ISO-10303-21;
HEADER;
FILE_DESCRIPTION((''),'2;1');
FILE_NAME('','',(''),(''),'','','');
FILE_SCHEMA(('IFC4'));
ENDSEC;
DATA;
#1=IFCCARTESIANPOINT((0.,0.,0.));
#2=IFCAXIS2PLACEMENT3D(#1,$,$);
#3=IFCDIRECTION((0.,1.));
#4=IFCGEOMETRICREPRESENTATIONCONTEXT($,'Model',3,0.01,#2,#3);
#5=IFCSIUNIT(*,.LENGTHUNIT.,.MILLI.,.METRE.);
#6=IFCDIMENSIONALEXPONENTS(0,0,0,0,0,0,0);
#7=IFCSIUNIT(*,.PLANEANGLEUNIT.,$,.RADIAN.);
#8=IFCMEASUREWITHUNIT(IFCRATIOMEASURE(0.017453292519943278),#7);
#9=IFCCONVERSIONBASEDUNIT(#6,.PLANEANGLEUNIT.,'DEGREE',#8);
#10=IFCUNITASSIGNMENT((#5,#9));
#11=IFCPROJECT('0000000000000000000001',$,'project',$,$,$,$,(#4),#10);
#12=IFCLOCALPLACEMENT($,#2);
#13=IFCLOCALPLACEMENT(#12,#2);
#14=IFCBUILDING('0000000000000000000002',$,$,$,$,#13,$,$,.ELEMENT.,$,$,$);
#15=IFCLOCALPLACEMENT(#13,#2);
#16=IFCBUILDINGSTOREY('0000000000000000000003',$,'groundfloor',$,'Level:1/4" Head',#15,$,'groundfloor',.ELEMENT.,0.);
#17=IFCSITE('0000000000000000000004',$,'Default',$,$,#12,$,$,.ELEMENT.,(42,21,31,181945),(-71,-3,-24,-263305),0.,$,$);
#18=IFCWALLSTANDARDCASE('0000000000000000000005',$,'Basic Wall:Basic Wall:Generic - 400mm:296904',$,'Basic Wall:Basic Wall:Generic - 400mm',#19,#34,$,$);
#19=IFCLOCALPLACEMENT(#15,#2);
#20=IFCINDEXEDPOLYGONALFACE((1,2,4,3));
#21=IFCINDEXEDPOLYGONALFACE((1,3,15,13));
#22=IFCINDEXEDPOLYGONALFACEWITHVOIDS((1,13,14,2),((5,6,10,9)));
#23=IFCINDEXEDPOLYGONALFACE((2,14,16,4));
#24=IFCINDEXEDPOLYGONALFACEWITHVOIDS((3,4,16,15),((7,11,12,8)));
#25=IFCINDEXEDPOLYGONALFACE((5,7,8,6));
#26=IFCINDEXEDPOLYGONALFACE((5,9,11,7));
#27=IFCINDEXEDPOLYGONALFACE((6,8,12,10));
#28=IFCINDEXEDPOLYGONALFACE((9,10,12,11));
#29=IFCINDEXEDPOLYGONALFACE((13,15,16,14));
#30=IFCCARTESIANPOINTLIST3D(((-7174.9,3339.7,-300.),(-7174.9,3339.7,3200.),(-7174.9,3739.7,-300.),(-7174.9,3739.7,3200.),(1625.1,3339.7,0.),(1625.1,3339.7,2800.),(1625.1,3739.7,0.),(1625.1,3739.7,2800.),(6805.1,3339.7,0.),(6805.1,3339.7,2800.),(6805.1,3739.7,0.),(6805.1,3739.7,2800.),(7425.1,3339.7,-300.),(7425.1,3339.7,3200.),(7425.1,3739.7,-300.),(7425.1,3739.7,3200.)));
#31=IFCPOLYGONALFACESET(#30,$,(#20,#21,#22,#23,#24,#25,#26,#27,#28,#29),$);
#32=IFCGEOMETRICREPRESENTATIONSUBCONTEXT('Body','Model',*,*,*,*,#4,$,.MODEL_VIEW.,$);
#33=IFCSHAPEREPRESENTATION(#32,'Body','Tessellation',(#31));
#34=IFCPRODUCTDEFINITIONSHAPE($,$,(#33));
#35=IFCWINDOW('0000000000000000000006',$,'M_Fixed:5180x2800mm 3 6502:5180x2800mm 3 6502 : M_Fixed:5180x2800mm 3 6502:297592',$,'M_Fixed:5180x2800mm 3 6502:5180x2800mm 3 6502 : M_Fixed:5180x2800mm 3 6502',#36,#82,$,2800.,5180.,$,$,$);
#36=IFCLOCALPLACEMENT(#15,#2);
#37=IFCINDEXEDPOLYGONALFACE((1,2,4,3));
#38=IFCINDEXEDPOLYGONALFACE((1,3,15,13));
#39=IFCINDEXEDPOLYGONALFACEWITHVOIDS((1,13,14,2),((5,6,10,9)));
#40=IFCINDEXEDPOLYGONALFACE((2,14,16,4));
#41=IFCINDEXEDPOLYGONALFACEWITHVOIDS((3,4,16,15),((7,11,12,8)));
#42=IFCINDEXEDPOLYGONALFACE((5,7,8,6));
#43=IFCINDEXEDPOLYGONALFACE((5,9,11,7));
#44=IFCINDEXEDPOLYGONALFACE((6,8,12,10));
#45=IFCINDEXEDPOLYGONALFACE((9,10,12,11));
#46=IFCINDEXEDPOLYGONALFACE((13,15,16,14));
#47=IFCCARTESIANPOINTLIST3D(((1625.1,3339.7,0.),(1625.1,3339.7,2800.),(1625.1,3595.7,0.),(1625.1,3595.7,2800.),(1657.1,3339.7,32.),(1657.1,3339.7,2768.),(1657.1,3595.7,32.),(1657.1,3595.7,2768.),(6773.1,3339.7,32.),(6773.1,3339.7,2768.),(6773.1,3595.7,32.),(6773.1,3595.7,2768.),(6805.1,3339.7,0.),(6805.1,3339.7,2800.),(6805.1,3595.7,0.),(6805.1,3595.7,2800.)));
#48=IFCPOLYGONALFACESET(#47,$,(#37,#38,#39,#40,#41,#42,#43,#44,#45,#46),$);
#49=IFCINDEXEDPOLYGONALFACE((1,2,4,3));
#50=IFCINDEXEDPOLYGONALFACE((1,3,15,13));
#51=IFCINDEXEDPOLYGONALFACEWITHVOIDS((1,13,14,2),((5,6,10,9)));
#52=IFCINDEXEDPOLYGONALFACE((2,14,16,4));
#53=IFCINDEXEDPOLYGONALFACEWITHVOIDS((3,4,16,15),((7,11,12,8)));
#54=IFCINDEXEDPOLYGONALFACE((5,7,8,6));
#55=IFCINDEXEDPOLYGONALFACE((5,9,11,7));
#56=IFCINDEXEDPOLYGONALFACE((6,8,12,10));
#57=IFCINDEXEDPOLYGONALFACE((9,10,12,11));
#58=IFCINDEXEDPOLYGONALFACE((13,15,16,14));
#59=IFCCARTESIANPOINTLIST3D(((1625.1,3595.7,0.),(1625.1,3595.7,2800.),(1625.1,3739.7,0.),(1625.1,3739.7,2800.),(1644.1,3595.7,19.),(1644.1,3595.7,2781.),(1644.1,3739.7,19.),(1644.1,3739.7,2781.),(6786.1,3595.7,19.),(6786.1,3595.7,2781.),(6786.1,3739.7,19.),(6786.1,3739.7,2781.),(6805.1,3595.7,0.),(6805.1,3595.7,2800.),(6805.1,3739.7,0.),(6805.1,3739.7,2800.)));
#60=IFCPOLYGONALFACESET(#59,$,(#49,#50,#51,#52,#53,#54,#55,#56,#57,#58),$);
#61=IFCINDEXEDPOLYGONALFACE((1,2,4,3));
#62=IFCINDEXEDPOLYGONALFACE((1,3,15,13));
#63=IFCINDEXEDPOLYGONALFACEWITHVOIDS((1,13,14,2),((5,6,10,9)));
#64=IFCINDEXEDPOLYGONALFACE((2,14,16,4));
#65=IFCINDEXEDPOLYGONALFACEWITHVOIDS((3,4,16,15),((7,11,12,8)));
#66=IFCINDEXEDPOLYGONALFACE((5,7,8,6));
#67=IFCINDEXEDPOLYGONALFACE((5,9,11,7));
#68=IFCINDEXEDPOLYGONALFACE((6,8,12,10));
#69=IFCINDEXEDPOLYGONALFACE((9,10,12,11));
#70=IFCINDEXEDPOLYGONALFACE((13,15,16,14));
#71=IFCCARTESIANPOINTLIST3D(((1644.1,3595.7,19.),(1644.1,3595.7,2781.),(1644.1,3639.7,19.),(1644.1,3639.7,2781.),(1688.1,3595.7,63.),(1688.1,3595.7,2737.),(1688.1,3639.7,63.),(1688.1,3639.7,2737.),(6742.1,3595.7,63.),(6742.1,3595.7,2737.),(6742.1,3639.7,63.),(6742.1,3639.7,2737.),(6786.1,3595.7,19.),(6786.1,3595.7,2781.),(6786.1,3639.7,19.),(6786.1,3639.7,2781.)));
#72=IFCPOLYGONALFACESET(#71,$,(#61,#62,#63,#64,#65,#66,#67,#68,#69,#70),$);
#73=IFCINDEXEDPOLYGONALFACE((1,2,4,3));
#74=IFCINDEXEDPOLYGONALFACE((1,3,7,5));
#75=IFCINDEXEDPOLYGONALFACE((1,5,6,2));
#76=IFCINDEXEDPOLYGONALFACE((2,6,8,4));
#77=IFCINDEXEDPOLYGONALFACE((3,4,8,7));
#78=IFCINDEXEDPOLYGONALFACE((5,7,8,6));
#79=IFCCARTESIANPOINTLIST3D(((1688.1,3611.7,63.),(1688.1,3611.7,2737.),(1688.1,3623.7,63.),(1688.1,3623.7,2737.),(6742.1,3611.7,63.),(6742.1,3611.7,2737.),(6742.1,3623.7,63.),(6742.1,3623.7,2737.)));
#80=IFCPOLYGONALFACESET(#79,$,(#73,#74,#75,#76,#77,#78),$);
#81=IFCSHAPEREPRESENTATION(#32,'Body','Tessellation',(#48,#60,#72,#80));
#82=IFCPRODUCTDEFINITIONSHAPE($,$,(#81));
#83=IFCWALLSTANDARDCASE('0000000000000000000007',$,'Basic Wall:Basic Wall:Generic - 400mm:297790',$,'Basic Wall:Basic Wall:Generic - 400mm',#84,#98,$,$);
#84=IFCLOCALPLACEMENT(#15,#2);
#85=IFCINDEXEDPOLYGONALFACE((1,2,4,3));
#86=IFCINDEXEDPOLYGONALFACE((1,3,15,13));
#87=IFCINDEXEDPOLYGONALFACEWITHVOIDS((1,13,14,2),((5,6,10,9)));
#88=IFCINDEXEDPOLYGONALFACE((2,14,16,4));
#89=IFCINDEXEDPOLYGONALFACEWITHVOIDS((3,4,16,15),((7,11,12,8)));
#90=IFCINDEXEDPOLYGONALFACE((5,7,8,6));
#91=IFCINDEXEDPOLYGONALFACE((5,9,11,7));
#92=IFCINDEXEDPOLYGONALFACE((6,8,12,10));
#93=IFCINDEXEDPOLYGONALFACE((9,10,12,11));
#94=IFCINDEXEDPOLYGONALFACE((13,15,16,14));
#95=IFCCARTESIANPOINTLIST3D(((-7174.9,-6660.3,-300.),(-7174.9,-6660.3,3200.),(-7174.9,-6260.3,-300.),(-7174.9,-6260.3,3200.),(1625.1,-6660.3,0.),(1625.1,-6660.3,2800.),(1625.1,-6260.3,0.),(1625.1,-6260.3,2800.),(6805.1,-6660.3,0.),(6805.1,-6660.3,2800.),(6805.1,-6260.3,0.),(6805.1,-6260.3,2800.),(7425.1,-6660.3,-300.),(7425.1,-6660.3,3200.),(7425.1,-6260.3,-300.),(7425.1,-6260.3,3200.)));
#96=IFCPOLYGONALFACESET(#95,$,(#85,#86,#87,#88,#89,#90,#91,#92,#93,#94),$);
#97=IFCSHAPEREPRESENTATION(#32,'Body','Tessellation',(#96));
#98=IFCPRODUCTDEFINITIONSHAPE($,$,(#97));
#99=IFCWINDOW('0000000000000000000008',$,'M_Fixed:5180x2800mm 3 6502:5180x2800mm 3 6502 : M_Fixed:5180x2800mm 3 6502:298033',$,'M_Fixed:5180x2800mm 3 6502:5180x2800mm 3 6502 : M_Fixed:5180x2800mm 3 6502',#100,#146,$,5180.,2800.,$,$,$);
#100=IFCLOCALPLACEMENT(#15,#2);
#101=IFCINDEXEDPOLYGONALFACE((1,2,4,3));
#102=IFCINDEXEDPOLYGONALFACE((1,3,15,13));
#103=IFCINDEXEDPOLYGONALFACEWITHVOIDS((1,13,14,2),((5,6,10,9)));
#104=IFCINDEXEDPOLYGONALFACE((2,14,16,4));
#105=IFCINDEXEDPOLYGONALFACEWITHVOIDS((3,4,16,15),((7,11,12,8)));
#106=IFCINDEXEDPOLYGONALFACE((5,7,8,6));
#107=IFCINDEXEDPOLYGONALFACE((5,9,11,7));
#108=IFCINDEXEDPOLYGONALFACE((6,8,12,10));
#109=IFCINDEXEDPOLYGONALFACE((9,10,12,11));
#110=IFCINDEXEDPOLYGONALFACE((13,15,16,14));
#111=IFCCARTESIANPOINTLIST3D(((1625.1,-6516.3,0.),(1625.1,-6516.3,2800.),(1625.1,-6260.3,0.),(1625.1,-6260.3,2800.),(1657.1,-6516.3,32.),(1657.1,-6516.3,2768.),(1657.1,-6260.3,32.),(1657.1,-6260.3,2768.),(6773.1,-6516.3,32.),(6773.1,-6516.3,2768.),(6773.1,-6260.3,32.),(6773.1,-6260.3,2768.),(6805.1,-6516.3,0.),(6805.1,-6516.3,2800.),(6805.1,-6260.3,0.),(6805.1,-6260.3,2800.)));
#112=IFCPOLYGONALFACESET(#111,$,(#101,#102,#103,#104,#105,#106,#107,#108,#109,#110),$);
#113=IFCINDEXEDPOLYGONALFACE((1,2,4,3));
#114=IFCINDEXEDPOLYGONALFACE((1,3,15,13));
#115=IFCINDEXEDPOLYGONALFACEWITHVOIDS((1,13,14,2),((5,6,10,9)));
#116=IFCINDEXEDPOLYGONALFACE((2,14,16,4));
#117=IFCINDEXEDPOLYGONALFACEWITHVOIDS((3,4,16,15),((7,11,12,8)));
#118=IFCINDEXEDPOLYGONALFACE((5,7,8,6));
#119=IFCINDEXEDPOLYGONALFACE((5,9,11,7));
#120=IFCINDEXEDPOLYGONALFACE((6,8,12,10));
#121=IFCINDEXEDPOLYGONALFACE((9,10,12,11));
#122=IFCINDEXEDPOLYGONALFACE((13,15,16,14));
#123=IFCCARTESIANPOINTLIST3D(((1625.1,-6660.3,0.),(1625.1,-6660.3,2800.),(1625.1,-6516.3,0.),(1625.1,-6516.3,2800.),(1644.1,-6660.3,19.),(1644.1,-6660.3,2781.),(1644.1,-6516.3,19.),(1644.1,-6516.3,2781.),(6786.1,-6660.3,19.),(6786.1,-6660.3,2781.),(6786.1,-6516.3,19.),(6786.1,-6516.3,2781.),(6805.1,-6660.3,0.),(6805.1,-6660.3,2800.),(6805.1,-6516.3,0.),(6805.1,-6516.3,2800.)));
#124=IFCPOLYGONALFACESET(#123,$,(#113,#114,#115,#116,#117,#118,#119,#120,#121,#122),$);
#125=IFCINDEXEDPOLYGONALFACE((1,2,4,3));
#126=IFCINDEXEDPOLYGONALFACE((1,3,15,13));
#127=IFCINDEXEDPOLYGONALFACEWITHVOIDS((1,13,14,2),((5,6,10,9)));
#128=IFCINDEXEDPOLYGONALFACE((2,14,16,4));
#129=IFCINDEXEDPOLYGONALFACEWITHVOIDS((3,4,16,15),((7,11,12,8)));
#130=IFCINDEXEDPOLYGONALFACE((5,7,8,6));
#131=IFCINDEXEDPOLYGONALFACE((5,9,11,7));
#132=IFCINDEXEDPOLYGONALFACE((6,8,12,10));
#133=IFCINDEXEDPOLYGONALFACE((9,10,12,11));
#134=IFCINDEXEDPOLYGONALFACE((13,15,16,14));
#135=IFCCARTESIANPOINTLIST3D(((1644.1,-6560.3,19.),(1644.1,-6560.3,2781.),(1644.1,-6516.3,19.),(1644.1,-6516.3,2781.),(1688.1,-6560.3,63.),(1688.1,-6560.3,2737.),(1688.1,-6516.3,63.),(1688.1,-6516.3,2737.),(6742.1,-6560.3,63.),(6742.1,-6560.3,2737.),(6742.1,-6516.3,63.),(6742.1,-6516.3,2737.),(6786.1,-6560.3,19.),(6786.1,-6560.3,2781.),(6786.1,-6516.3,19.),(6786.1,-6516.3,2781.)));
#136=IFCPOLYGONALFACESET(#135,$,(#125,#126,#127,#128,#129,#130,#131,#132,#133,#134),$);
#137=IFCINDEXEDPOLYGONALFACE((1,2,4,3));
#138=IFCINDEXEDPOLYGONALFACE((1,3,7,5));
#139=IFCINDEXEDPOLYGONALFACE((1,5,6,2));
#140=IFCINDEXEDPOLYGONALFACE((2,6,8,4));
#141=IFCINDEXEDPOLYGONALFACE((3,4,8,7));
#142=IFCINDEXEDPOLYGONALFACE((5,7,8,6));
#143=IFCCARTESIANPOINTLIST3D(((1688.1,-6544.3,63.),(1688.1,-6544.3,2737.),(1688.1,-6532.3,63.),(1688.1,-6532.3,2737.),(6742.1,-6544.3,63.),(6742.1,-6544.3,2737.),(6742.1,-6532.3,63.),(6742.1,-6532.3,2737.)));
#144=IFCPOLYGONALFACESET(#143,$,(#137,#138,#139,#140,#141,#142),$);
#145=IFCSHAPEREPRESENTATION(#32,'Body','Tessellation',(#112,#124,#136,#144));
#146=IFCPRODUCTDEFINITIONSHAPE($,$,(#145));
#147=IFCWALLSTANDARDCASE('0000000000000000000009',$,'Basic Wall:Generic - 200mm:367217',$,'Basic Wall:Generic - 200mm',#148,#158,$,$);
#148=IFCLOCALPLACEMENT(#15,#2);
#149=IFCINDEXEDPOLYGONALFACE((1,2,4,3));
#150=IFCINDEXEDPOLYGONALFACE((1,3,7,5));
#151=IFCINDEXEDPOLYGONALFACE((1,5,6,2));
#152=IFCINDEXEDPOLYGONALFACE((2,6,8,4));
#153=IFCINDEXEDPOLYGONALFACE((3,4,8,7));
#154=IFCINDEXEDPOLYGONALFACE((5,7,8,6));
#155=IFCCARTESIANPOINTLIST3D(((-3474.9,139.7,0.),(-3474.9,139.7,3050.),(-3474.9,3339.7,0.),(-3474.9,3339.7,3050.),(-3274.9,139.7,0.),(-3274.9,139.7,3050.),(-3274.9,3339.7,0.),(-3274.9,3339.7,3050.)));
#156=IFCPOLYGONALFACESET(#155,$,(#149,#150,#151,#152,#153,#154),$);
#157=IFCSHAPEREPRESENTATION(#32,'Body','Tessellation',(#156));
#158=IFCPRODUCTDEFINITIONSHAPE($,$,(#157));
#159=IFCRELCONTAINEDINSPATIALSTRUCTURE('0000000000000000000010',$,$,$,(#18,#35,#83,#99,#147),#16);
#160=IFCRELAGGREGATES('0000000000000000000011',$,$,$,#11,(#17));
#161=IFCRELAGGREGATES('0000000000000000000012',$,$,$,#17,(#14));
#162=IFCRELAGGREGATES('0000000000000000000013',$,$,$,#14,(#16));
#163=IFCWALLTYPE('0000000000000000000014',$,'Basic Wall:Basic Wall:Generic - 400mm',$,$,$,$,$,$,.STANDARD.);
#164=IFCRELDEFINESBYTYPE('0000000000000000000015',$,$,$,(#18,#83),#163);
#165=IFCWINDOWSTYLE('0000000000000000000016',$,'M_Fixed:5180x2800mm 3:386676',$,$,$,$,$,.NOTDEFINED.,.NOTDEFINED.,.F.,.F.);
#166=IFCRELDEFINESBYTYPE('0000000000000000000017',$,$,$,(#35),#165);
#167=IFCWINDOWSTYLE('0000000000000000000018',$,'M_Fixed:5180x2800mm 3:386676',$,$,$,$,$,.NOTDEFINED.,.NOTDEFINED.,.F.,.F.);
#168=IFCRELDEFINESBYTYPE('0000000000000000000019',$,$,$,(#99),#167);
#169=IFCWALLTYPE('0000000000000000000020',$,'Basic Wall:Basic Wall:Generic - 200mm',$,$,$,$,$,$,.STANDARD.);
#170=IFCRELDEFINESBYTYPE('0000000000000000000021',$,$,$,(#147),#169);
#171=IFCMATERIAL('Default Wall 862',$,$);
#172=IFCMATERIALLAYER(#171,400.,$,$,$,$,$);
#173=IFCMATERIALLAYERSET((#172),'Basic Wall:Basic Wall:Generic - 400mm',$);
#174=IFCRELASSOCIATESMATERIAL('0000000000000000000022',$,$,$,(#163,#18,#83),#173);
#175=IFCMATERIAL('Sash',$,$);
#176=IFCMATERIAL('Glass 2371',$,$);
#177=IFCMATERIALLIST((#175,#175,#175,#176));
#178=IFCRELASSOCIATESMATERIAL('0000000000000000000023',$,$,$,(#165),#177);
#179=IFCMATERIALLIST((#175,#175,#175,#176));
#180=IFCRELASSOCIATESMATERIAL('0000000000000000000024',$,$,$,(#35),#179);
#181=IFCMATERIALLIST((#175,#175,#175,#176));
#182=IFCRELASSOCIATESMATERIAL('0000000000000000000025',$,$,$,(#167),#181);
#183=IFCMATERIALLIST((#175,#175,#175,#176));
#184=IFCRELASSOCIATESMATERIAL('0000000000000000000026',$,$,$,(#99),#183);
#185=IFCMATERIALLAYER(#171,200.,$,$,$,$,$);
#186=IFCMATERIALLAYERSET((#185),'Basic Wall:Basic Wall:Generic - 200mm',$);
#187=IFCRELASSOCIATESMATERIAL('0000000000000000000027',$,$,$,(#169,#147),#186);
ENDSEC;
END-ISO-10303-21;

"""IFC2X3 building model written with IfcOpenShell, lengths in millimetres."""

from ifc_helpers import new_model, entity, si_unit, converted_unit, direction, frame, frame_2d, origin, origin_2d_with_axis, place, context, subcontext, project, spatial, polyline, rectangle, outline, extrude, source, transform, mapped, material, material_list, layer, layer_set, layer_usage, type_object, type_shapes, element, fill, save


model = new_model("IFC2X3")

# Units and contexts
model_context = context("Model", 3, precision=0.01, world=origin(), true_north=direction((0.0, 1.0)))
body_context = subcontext(model_context, "Body", "Model", "MODEL_VIEW")
ifc_project = project(units=[si_unit("LENGTHUNIT", "METRE", prefix="MILLI"), converted_unit("PLANEANGLEUNIT", "DEGREE", entity("IfcRatioMeasure", 0.017453292519943278), si_unit("PLANEANGLEUNIT", "RADIAN"), dimensions=[0, 0, 0, 0, 0, 0, 0])], contexts=[model_context])

# Site, building, storey
site_placement = place(None, origin())
site = spatial("IfcSite", under=ifc_project, at=site_placement, Name="Default", CompositionType="ELEMENT", RefLatitude=(42, 21, 31, 181945), RefLongitude=(-71, -3, -24, -263305), RefElevation=0.0)
building_placement = place(site_placement, origin())
building = spatial("IfcBuilding", under=site, at=building_placement, CompositionType="ELEMENT")
storey_placement = place(building_placement, origin())
storey = spatial("IfcBuildingStorey", under=building, at=storey_placement, Name="groundfloor", ObjectType="Level:1/4\" Head", LongName="groundfloor", CompositionType="ELEMENT", Elevation=0.0)

# Shared definitions
ifc_material_1 = material(Name="Default Wall 862")
ifc_layer_1 = layer(ifc_material_1, 400.0)
ifc_layer_set_1 = layer_set([ifc_layer_1], Name="Basic Wall:Basic Wall:Generic - 400mm")
wall_type_1 = type_object("IfcWallType", Name="Basic Wall:Basic Wall:Generic - 400mm", PredefinedType="STANDARD", material=ifc_layer_set_1)
ifc_material_2 = material(Name="Sash")
ifc_material_3 = material(Name="Glass 2371")

# Walls, openings, windows
ifc_layer_usage_1 = layer_usage(ifc_layer_set_1, "AXIS2", "NEGATIVE", 200.0)
wall_1_placement = place(storey_placement, frame((-7174.9, 3539.7, -300.0)))
wall_1 = element("IfcWallStandardCase", 1, at=wall_1_placement, inside=storey, type_object=wall_type_1, material=ifc_layer_usage_1, Name="Basic Wall:Basic Wall:Generic - 400mm:296904", ObjectType="Basic Wall:Basic Wall:Generic - 400mm", context=body_context, shape_type="SweptSolid", body=[
    extrude(rectangle(XDim=14600.0, YDim=400.0, at=frame_2d((7300.0, 0.0), x_axis=(-1.0, 0.0))), origin(), (0.0, 0.0, 1.0), 3500.0),
])
opening_1_placement = place(wall_1_placement, frame((7174.9, -3539.7, 300.0)))
opening_1 = element("IfcOpeningElement", 2, at=opening_1_placement, cuts=wall_1, ObjectType="Opening", context=body_context, shape_type="SweptSolid", body=[
    extrude(rectangle(XDim=2800.0, YDim=5180.0, at=frame_2d((0.0, 0.0), x_axis=(0.0, 1.0))), frame((4215.1, 3335.7, 1400.0), z_axis=(0.0, 1.0, 0.0), x_axis=(1.0, 0.0, 0.0)), (0.0, 0.0, 1.0), 408.0),
])
ifc_material_list_1 = material_list([ifc_material_2, ifc_material_2, ifc_material_2, ifc_material_3])
ifc_material_list_2 = material_list([ifc_material_2, ifc_material_2, ifc_material_2, ifc_material_3])
window_style_1 = type_object("IfcWindowStyle", Name="M_Fixed:5180x2800mm 3:386676", ConstructionType="NOTDEFINED", OperationType="NOTDEFINED", ParameterTakesPrecedence=False, Sizeable=False, material=ifc_material_list_2)
shared_shape_1 = source(origin(), body_context, "Body", "SweptSolid", [
    extrude(outline(polyline([(-2590.0, -1400.0), (2590.0, -1400.0), (2590.0, 1400.0), (-2590.0, 1400.0), (-2590.0, -1400.0)]), holes=[polyline([(2558.0, 1368.0), (2558.0, -1368.0), (-2558.0, -1368.0), (-2558.0, 1368.0), (2558.0, 1368.0)])]), frame((2590.0, -404.0, 1400.0), z_axis=(0.0, 1.0, 0.0), x_axis=(1.0, 0.0, 0.0)), (0.0, 0.0, 1.0), 256.0),
    extrude(outline(polyline([(-2590.0, -1400.0), (2590.0, -1400.0), (2590.0, 1400.0), (-2590.0, 1400.0), (-2590.0, -1400.0)]), holes=[polyline([(2571.0, 1381.0), (2571.0, -1381.0), (-2571.0, -1381.0), (-2571.0, 1381.0), (2571.0, 1381.0)])]), frame((2590.0, -148.0, 1400.0), z_axis=(0.0, 1.0, 0.0), x_axis=(1.0, 0.0, 0.0)), (0.0, 0.0, 1.0), 144.0),
    extrude(outline(polyline([(-2571.0, -1381.0), (2571.0, -1381.0), (2571.0, 1381.0), (-2571.0, 1381.0), (-2571.0, -1381.0)]), holes=[polyline([(2527.0, 1337.0), (2527.0, -1337.0), (-2527.0, -1337.0), (-2527.0, 1337.0), (2527.0, 1337.0)])]), frame((2590.0, -148.0, 1400.0), z_axis=(0.0, 1.0, 0.0), x_axis=(1.0, 0.0, 0.0)), (0.0, 0.0, 1.0), 44.0),
    extrude(rectangle(XDim=12.0, YDim=5054.0, at=origin_2d_with_axis()), frame((2590.0, -126.0, 63.0), z_axis=(0.0, 0.0, 1.0), x_axis=(0.0, -1.0, 0.0)), (0.0, 0.0, 1.0), 2674.0),
])
type_shapes(window_style_1, [shared_shape_1])
window_1_placement = place(opening_1_placement, frame((1625.1, 3743.7, 0.0)))
window_1 = element("IfcWindow", 3, at=window_1_placement, inside=storey, type_object=window_style_1, material=ifc_material_list_1, Name="M_Fixed:5180x2800mm 3 6502:5180x2800mm 3 6502 : M_Fixed:5180x2800mm 3 6502:297592", ObjectType="M_Fixed:5180x2800mm 3 6502:5180x2800mm 3 6502 : M_Fixed:5180x2800mm 3 6502", OverallHeight=2800.0, OverallWidth=5180.0, context=body_context, shape_type="MappedRepresentation", body=[
    mapped(shared_shape_1, transform((0.0, 0.0, 0.0), scale=1.0)),
])
fill(opening_1, window_1)
ifc_layer_usage_2 = layer_usage(ifc_layer_set_1, "AXIS2", "NEGATIVE", 200.0)
wall_2_placement = place(storey_placement, frame((-7174.9, -6460.3, -300.0)))
wall_2 = element("IfcWallStandardCase", 4, at=wall_2_placement, inside=storey, type_object=wall_type_1, material=ifc_layer_usage_2, Name="Basic Wall:Basic Wall:Generic - 400mm:297790", ObjectType="Basic Wall:Basic Wall:Generic - 400mm", context=body_context, shape_type="SweptSolid", body=[
    extrude(rectangle(XDim=14600.0, YDim=400.0, at=frame_2d((7300.0, 0.0), x_axis=(-1.0, 0.0))), origin(), (0.0, 0.0, 1.0), 3500.0),
])
opening_2_placement = place(wall_2_placement, frame((7174.9, 6460.3, 300.0)))
opening_2 = element("IfcOpeningElement", 5, at=opening_2_placement, cuts=wall_2, ObjectType="Opening", context=body_context, shape_type="SweptSolid", body=[
    extrude(rectangle(XDim=2800.0, YDim=5180.0, at=origin_2d_with_axis()), frame((4215.1, -6664.3, 1400.0), z_axis=(0.0, 1.0, 0.0), x_axis=(0.0, 0.0, -1.0)), (0.0, 0.0, 1.0), 408.0),
])
ifc_material_list_3 = material_list([ifc_material_2, ifc_material_2, ifc_material_2, ifc_material_3])
ifc_material_list_4 = material_list([ifc_material_2, ifc_material_2, ifc_material_2, ifc_material_3])
window_style_2 = type_object("IfcWindowStyle", Name="M_Fixed:5180x2800mm 3:386676", ConstructionType="NOTDEFINED", OperationType="NOTDEFINED", ParameterTakesPrecedence=False, Sizeable=False, material=ifc_material_list_4)
shared_shape_2 = source(origin(), body_context, "Body", "SweptSolid", [
    extrude(outline(polyline([(-2590.0, -1400.0), (2590.0, -1400.0), (2590.0, 1400.0), (-2590.0, 1400.0), (-2590.0, -1400.0)]), holes=[polyline([(2558.0, 1368.0), (2558.0, -1368.0), (-2558.0, -1368.0), (-2558.0, 1368.0), (2558.0, 1368.0)])]), frame((2590.0, 4.0, 1400.0), z_axis=(0.0, 1.0, 0.0), x_axis=(1.0, 0.0, 0.0)), (0.0, 0.0, 1.0), 256.0),
    extrude(outline(polyline([(-2590.0, -1400.0), (2590.0, -1400.0), (2590.0, 1400.0), (-2590.0, 1400.0), (-2590.0, -1400.0)]), holes=[polyline([(2571.0, 1381.0), (2571.0, -1381.0), (-2571.0, -1381.0), (-2571.0, 1381.0), (2571.0, 1381.0)])]), frame((2590.0, 260.0, 1400.0), z_axis=(0.0, 1.0, 0.0), x_axis=(1.0, 0.0, 0.0)), (0.0, 0.0, 1.0), 144.0),
    extrude(outline(polyline([(-2571.0, -1381.0), (2571.0, -1381.0), (2571.0, 1381.0), (-2571.0, 1381.0), (-2571.0, -1381.0)]), holes=[polyline([(2527.0, 1337.0), (2527.0, -1337.0), (-2527.0, -1337.0), (-2527.0, 1337.0), (2527.0, 1337.0)])]), frame((2590.0, 260.0, 1400.0), z_axis=(0.0, 1.0, 0.0), x_axis=(1.0, 0.0, 0.0)), (0.0, 0.0, 1.0), 44.0),
    extrude(rectangle(XDim=12.0, YDim=5054.0, at=origin_2d_with_axis()), frame((2590.0, 282.0, 63.0), z_axis=(0.0, 0.0, 1.0), x_axis=(0.0, -1.0, 0.0)), (0.0, 0.0, 1.0), 2674.0),
])
type_shapes(window_style_2, [shared_shape_2])
window_2_placement = place(opening_2_placement, frame((6805.1, -6256.3, 0.0), z_axis=(0.0, 0.0, 1.0), x_axis=(-1.0, 0.0, 0.0)))
window_2 = element("IfcWindow", 6, at=window_2_placement, inside=storey, type_object=window_style_2, material=ifc_material_list_3, Name="M_Fixed:5180x2800mm 3 6502:5180x2800mm 3 6502 : M_Fixed:5180x2800mm 3 6502:298033", ObjectType="M_Fixed:5180x2800mm 3 6502:5180x2800mm 3 6502 : M_Fixed:5180x2800mm 3 6502", OverallHeight=5180.0, OverallWidth=2800.0, context=body_context, shape_type="MappedRepresentation", body=[
    mapped(shared_shape_2, transform((0.0, 0.0, 0.0), scale=1.0)),
])
fill(opening_2, window_2)

# Wall
ifc_layer_2 = layer(ifc_material_1, 200.0)
ifc_layer_set_2 = layer_set([ifc_layer_2], Name="Basic Wall:Basic Wall:Generic - 200mm")
ifc_layer_usage_3 = layer_usage(ifc_layer_set_2, "AXIS2", "NEGATIVE", 100.0)
wall_type_2 = type_object("IfcWallType", Name="Basic Wall:Basic Wall:Generic - 200mm", PredefinedType="STANDARD", material=ifc_layer_set_2)
wall_3_placement = place(storey_placement, frame((-3374.9, 3339.7, 0.0), z_axis=(0.0, 0.0, 1.0), x_axis=(0.0, -1.0, 0.0)))
element("IfcWallStandardCase", 7, at=wall_3_placement, inside=storey, type_object=wall_type_2, material=ifc_layer_usage_3, Name="Basic Wall:Generic - 200mm:367217", ObjectType="Basic Wall:Generic - 200mm", context=body_context, shape_type="SweptSolid", body=[
    extrude(rectangle(XDim=3200.0, YDim=200.0, at=frame_2d((1600.0, 0.0), x_axis=(-1.0, 0.0))), origin(), (0.0, 0.0, 1.0), 3050.0),
])

save(model, "model.ifc")
